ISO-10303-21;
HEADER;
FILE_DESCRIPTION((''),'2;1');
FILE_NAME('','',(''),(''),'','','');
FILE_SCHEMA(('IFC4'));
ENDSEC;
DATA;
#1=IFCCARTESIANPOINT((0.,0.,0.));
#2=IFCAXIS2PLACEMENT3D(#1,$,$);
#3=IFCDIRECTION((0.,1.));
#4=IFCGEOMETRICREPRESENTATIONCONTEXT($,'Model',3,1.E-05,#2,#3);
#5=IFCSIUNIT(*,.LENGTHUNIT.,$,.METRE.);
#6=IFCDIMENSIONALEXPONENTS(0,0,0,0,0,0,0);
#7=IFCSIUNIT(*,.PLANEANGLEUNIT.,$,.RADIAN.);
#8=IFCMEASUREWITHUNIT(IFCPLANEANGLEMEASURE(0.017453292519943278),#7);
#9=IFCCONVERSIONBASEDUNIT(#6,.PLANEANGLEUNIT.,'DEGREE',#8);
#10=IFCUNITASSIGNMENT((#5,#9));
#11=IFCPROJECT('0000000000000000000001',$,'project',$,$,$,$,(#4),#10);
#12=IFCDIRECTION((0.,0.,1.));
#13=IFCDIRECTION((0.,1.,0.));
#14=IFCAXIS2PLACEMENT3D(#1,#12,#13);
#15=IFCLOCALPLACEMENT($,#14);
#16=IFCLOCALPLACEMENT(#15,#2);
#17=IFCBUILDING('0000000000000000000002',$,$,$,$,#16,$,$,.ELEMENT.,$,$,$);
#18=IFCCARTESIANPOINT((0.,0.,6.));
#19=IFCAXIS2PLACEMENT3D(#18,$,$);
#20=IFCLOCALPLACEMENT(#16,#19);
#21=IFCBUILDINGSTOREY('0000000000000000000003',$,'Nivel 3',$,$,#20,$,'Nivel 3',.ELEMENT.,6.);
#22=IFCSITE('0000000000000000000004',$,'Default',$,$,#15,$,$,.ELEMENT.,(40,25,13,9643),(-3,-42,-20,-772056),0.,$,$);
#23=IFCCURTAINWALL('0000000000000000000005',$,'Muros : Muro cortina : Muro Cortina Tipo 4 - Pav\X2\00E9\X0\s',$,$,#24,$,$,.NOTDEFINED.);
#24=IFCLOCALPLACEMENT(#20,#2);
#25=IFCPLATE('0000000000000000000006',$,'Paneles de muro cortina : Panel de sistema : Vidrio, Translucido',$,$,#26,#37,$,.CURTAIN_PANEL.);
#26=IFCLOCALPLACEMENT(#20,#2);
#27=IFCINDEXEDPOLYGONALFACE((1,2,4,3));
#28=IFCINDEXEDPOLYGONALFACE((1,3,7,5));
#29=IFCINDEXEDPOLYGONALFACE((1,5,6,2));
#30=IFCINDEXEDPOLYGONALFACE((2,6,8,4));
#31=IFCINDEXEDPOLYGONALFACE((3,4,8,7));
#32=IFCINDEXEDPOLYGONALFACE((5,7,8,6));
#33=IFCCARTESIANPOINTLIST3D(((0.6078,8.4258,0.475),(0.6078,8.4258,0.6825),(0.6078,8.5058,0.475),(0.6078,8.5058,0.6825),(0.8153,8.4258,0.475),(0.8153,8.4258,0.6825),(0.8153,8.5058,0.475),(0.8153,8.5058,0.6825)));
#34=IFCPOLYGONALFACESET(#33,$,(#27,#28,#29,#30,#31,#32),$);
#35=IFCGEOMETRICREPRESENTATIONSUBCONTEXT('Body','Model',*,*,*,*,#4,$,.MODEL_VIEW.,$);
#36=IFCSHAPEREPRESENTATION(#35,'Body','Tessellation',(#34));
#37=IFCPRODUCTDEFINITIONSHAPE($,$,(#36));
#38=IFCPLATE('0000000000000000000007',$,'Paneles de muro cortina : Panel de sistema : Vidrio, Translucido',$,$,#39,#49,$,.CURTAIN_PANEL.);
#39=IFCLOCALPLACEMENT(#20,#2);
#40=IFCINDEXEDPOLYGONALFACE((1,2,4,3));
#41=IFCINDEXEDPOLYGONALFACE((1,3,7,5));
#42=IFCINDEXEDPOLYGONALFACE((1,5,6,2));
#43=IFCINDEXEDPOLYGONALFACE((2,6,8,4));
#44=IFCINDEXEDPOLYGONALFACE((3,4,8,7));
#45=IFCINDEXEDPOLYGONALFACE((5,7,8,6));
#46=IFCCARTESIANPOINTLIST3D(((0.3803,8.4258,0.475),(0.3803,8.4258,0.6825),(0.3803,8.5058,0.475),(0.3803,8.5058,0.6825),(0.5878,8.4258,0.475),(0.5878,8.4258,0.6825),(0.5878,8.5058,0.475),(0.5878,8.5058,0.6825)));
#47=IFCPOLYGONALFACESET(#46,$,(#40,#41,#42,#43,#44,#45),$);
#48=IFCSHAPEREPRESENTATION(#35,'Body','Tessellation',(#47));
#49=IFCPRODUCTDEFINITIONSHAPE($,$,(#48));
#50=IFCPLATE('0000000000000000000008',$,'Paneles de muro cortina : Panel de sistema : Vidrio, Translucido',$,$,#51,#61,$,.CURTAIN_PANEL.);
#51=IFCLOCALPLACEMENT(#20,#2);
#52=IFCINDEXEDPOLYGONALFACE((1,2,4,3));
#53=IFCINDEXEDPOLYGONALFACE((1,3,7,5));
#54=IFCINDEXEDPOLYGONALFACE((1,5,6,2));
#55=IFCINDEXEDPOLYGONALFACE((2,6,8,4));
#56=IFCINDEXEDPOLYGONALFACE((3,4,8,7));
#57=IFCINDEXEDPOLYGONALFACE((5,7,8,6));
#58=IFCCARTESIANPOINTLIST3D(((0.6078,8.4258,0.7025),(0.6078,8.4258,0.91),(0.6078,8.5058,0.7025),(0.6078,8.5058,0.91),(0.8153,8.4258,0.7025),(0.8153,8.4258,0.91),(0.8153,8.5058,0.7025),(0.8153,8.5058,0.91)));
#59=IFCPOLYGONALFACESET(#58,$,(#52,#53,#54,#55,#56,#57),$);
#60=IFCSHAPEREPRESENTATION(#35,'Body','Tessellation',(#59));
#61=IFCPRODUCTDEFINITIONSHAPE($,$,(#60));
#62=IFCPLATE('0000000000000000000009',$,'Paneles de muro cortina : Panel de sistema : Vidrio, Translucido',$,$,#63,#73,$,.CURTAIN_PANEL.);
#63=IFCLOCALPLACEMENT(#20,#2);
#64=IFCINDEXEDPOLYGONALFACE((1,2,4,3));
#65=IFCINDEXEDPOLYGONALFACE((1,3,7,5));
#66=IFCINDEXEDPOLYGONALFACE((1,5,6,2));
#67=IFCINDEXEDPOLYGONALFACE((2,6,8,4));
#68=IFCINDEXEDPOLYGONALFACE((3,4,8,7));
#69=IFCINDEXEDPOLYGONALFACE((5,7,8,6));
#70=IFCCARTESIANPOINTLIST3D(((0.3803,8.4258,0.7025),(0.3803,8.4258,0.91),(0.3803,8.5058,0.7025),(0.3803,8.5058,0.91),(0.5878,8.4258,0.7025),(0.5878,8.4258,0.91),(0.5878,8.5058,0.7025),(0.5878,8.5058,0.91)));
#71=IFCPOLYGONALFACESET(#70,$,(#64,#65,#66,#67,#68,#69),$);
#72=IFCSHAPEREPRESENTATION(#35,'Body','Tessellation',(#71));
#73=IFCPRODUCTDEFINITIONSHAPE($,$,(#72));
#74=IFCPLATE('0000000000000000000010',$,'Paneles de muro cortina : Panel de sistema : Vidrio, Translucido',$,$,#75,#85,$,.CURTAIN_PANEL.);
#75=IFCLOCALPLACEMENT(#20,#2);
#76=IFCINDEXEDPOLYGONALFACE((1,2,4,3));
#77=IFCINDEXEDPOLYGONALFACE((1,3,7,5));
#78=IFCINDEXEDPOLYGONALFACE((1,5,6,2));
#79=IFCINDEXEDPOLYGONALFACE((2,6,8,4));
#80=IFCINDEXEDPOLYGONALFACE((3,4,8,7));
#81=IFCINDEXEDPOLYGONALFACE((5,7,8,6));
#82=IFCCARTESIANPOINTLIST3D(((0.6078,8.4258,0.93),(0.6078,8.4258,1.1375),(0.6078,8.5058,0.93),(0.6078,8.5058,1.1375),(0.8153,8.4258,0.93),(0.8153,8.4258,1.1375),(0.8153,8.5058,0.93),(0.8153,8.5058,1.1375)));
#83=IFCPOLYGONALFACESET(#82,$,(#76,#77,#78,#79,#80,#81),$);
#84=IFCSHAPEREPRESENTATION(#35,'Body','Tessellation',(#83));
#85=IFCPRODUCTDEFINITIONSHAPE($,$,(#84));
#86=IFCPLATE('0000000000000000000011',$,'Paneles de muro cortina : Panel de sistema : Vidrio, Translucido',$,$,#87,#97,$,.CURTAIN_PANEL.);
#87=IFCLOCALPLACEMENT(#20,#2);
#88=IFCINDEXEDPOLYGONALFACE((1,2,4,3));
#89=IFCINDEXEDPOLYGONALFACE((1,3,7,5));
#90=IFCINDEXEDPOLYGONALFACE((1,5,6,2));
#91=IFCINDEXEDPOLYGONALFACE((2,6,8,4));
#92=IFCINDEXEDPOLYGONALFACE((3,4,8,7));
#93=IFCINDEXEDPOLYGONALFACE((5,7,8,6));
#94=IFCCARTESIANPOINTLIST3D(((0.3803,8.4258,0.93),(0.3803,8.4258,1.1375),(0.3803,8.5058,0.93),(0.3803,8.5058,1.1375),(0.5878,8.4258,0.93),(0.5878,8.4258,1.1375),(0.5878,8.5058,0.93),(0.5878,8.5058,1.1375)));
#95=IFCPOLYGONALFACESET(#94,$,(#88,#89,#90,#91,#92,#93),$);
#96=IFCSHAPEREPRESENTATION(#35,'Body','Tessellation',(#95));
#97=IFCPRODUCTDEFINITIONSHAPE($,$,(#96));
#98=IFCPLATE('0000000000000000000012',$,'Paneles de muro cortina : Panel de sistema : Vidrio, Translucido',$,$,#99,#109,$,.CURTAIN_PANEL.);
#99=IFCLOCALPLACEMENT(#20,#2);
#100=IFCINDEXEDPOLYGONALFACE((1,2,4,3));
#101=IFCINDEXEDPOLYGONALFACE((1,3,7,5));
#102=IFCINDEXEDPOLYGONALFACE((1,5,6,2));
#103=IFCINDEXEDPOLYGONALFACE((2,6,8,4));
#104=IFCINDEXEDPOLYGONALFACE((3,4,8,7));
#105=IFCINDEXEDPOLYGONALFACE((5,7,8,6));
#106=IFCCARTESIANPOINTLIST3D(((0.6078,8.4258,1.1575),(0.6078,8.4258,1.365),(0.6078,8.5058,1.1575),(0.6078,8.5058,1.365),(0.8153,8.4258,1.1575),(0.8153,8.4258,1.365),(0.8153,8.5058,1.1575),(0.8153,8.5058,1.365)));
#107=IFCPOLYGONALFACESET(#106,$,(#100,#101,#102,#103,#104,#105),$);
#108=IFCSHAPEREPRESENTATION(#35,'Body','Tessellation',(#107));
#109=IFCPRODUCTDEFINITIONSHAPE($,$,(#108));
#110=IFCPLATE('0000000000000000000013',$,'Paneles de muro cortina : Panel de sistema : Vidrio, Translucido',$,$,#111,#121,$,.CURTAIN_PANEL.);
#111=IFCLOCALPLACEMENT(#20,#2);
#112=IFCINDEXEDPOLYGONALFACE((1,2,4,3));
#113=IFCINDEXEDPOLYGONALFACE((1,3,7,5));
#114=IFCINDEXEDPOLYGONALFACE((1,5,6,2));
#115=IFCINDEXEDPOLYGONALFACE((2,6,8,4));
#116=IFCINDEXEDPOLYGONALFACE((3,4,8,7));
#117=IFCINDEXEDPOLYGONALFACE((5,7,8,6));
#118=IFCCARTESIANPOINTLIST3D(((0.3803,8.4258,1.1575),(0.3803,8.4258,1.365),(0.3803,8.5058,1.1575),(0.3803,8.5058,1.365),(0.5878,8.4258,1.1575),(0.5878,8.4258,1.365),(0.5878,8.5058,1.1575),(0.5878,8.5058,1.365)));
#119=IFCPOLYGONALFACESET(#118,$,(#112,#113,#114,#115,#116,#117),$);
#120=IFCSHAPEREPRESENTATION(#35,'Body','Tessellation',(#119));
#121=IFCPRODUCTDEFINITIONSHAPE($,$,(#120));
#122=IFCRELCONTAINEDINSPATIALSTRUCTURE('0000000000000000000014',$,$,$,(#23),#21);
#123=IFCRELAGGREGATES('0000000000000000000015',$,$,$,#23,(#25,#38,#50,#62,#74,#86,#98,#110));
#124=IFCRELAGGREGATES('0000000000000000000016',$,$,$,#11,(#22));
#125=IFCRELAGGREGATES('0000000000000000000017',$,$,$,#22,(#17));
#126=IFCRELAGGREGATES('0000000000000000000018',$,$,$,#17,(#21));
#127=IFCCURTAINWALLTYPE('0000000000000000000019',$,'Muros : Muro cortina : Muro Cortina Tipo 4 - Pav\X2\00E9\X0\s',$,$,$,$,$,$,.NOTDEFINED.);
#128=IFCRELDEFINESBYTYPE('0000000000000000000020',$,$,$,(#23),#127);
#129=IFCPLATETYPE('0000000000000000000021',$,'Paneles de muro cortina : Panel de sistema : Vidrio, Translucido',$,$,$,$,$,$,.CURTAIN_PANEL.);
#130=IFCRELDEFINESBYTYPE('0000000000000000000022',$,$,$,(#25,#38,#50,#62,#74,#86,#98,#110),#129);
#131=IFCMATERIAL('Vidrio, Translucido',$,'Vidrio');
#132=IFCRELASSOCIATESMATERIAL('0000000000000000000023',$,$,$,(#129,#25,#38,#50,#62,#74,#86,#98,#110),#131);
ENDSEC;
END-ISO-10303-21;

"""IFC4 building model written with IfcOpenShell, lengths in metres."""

from ifc_helpers import new_model, entity, si_unit, converted_unit, direction, frame, origin, place, context, subcontext, project, spatial, indexed_curve, outline, extrude, source, transform, mapped, material, type_object, type_shapes, element, aggregate, save


model = new_model("IFC4")

# Units and contexts
model_context = context("Model", 3, precision=1e-05, world=origin(), true_north=direction((0.0, 1.0)))
body_context = subcontext(model_context, "Body", "Model", "MODEL_VIEW")
ifc_project = project(units=[si_unit("LENGTHUNIT", "METRE"), converted_unit("PLANEANGLEUNIT", "DEGREE", entity("IfcPlaneAngleMeasure", 0.017453292519943278), si_unit("PLANEANGLEUNIT", "RADIAN"), dimensions=[0, 0, 0, 0, 0, 0, 0])], contexts=[model_context])

# Site, building, storey
site_placement = place(None, frame((0.0, 0.0, 0.0), z_axis=(0.0, 0.0, 1.0), x_axis=(0.0, 1.0, 0.0)))
site = spatial("IfcSite", under=ifc_project, at=site_placement, Name="Default", CompositionType="ELEMENT", RefLatitude=(40, 25, 13, 9643), RefLongitude=(-3, -42, -20, -772056), RefElevation=0.0)
building_placement = place(site_placement, origin())
building = spatial("IfcBuilding", under=site, at=building_placement, CompositionType="ELEMENT")
storey_placement = place(building_placement, frame((0.0, 0.0, 6.0)))
storey = spatial("IfcBuildingStorey", under=building, at=storey_placement, Name="Nivel 3", LongName="Nivel 3", CompositionType="ELEMENT", Elevation=6.0)

# Curtain wall, plates
curtain_wall_type = type_object("IfcCurtainWallType", Name="Muros : Muro cortina : Muro Cortina Tipo 4 - Pavés", PredefinedType="NOTDEFINED")
curtain_wall_placement = place(storey_placement, frame((0.0, 0.0, -6.0)))
curtain_wall = element("IfcCurtainWall", 1, at=curtain_wall_placement, inside=storey, type_object=curtain_wall_type, Name="Muros : Muro cortina : Muro Cortina Tipo 4 - Pavés", PredefinedType="NOTDEFINED")
ifc_material_1 = material(Name="Vidrio, Translucido", Category="Vidrio")
plate_type = type_object("IfcPlateType", Name="Paneles de muro cortina : Panel de sistema : Vidrio, Translucido", PredefinedType="CURTAIN_PANEL", material=ifc_material_1)
shared_shape_1 = source(origin(), body_context, "Body", "SweptSolid", [
    extrude(outline(indexed_curve([(-0.04, -0.1038), (0.04, -0.1038), (0.04, 0.1038), (-0.04, 0.1038), (-0.04, -0.1038)], self_intersect=False)), frame((0.0, 0.0, 0.0), z_axis=(0.0, 0.0, 1.0), x_axis=(0.0, 1.0, 0.0)), (0.0, 0.0, 1.0), 0.2075),
])
type_shapes(plate_type, [shared_shape_1])
plate_1_placement = place(curtain_wall_placement, frame((0.7115, 8.4658, 6.475), z_axis=(0.0, 0.0, 1.0), x_axis=(-1.0, 0.0, 0.0)))
plate_1 = element("IfcPlate", 2, at=plate_1_placement, type_object=plate_type, material=ifc_material_1, Name="Paneles de muro cortina : Panel de sistema : Vidrio, Translucido", PredefinedType="CURTAIN_PANEL", context=body_context, shape_type="MappedRepresentation", body=[
    mapped(shared_shape_1, transform((0.0, 0.0, 0.0), scale=1.0)),
])
plate_2_placement = place(curtain_wall_placement, frame((0.484, 8.4658, 6.475), z_axis=(0.0, 0.0, 1.0), x_axis=(-1.0, 0.0, 0.0)))
plate_2 = element("IfcPlate", 3, at=plate_2_placement, type_object=plate_type, material=ifc_material_1, Name="Paneles de muro cortina : Panel de sistema : Vidrio, Translucido", PredefinedType="CURTAIN_PANEL", context=body_context, shape_type="MappedRepresentation", body=[
    mapped(shared_shape_1, transform((0.0, 0.0, 0.0), scale=1.0)),
])
plate_3_placement = place(curtain_wall_placement, frame((0.7115, 8.4658, 6.7025), z_axis=(0.0, 0.0, 1.0), x_axis=(-1.0, 0.0, 0.0)))
plate_3 = element("IfcPlate", 4, at=plate_3_placement, type_object=plate_type, material=ifc_material_1, Name="Paneles de muro cortina : Panel de sistema : Vidrio, Translucido", PredefinedType="CURTAIN_PANEL", context=body_context, shape_type="MappedRepresentation", body=[
    mapped(shared_shape_1, transform((0.0, 0.0, 0.0), scale=1.0)),
])
plate_4_placement = place(curtain_wall_placement, frame((0.484, 8.4658, 6.7025), z_axis=(0.0, 0.0, 1.0), x_axis=(-1.0, 0.0, 0.0)))
plate_4 = element("IfcPlate", 5, at=plate_4_placement, type_object=plate_type, material=ifc_material_1, Name="Paneles de muro cortina : Panel de sistema : Vidrio, Translucido", PredefinedType="CURTAIN_PANEL", context=body_context, shape_type="MappedRepresentation", body=[
    mapped(shared_shape_1, transform((0.0, 0.0, 0.0), scale=1.0)),
])
plate_5_placement = place(curtain_wall_placement, frame((0.7115, 8.4658, 6.93), z_axis=(0.0, 0.0, 1.0), x_axis=(-1.0, 0.0, 0.0)))
plate_5 = element("IfcPlate", 6, at=plate_5_placement, type_object=plate_type, material=ifc_material_1, Name="Paneles de muro cortina : Panel de sistema : Vidrio, Translucido", PredefinedType="CURTAIN_PANEL", context=body_context, shape_type="MappedRepresentation", body=[
    mapped(shared_shape_1, transform((0.0, 0.0, 0.0), scale=1.0)),
])
plate_6_placement = place(curtain_wall_placement, frame((0.484, 8.4658, 6.93), z_axis=(0.0, 0.0, 1.0), x_axis=(-1.0, 0.0, 0.0)))
plate_6 = element("IfcPlate", 7, at=plate_6_placement, type_object=plate_type, material=ifc_material_1, Name="Paneles de muro cortina : Panel de sistema : Vidrio, Translucido", PredefinedType="CURTAIN_PANEL", context=body_context, shape_type="MappedRepresentation", body=[
    mapped(shared_shape_1, transform((0.0, 0.0, 0.0), scale=1.0)),
])
plate_7_placement = place(curtain_wall_placement, frame((0.7115, 8.4658, 7.1575), z_axis=(0.0, 0.0, 1.0), x_axis=(-1.0, 0.0, 0.0)))
plate_7 = element("IfcPlate", 8, at=plate_7_placement, type_object=plate_type, material=ifc_material_1, Name="Paneles de muro cortina : Panel de sistema : Vidrio, Translucido", PredefinedType="CURTAIN_PANEL", context=body_context, shape_type="MappedRepresentation", body=[
    mapped(shared_shape_1, transform((0.0, 0.0, 0.0), scale=1.0)),
])
plate_8_placement = place(curtain_wall_placement, frame((0.484, 8.4658, 7.1575), z_axis=(0.0, 0.0, 1.0), x_axis=(-1.0, 0.0, 0.0)))
plate_8 = element("IfcPlate", 9, at=plate_8_placement, type_object=plate_type, material=ifc_material_1, Name="Paneles de muro cortina : Panel de sistema : Vidrio, Translucido", PredefinedType="CURTAIN_PANEL", context=body_context, shape_type="MappedRepresentation", body=[
    mapped(shared_shape_1, transform((0.0, 0.0, 0.0), scale=1.0)),
])
aggregate(curtain_wall, [plate_1, plate_2, plate_3, plate_4, plate_5, plate_6, plate_7, plate_8])

save(model, "model.ifc")
